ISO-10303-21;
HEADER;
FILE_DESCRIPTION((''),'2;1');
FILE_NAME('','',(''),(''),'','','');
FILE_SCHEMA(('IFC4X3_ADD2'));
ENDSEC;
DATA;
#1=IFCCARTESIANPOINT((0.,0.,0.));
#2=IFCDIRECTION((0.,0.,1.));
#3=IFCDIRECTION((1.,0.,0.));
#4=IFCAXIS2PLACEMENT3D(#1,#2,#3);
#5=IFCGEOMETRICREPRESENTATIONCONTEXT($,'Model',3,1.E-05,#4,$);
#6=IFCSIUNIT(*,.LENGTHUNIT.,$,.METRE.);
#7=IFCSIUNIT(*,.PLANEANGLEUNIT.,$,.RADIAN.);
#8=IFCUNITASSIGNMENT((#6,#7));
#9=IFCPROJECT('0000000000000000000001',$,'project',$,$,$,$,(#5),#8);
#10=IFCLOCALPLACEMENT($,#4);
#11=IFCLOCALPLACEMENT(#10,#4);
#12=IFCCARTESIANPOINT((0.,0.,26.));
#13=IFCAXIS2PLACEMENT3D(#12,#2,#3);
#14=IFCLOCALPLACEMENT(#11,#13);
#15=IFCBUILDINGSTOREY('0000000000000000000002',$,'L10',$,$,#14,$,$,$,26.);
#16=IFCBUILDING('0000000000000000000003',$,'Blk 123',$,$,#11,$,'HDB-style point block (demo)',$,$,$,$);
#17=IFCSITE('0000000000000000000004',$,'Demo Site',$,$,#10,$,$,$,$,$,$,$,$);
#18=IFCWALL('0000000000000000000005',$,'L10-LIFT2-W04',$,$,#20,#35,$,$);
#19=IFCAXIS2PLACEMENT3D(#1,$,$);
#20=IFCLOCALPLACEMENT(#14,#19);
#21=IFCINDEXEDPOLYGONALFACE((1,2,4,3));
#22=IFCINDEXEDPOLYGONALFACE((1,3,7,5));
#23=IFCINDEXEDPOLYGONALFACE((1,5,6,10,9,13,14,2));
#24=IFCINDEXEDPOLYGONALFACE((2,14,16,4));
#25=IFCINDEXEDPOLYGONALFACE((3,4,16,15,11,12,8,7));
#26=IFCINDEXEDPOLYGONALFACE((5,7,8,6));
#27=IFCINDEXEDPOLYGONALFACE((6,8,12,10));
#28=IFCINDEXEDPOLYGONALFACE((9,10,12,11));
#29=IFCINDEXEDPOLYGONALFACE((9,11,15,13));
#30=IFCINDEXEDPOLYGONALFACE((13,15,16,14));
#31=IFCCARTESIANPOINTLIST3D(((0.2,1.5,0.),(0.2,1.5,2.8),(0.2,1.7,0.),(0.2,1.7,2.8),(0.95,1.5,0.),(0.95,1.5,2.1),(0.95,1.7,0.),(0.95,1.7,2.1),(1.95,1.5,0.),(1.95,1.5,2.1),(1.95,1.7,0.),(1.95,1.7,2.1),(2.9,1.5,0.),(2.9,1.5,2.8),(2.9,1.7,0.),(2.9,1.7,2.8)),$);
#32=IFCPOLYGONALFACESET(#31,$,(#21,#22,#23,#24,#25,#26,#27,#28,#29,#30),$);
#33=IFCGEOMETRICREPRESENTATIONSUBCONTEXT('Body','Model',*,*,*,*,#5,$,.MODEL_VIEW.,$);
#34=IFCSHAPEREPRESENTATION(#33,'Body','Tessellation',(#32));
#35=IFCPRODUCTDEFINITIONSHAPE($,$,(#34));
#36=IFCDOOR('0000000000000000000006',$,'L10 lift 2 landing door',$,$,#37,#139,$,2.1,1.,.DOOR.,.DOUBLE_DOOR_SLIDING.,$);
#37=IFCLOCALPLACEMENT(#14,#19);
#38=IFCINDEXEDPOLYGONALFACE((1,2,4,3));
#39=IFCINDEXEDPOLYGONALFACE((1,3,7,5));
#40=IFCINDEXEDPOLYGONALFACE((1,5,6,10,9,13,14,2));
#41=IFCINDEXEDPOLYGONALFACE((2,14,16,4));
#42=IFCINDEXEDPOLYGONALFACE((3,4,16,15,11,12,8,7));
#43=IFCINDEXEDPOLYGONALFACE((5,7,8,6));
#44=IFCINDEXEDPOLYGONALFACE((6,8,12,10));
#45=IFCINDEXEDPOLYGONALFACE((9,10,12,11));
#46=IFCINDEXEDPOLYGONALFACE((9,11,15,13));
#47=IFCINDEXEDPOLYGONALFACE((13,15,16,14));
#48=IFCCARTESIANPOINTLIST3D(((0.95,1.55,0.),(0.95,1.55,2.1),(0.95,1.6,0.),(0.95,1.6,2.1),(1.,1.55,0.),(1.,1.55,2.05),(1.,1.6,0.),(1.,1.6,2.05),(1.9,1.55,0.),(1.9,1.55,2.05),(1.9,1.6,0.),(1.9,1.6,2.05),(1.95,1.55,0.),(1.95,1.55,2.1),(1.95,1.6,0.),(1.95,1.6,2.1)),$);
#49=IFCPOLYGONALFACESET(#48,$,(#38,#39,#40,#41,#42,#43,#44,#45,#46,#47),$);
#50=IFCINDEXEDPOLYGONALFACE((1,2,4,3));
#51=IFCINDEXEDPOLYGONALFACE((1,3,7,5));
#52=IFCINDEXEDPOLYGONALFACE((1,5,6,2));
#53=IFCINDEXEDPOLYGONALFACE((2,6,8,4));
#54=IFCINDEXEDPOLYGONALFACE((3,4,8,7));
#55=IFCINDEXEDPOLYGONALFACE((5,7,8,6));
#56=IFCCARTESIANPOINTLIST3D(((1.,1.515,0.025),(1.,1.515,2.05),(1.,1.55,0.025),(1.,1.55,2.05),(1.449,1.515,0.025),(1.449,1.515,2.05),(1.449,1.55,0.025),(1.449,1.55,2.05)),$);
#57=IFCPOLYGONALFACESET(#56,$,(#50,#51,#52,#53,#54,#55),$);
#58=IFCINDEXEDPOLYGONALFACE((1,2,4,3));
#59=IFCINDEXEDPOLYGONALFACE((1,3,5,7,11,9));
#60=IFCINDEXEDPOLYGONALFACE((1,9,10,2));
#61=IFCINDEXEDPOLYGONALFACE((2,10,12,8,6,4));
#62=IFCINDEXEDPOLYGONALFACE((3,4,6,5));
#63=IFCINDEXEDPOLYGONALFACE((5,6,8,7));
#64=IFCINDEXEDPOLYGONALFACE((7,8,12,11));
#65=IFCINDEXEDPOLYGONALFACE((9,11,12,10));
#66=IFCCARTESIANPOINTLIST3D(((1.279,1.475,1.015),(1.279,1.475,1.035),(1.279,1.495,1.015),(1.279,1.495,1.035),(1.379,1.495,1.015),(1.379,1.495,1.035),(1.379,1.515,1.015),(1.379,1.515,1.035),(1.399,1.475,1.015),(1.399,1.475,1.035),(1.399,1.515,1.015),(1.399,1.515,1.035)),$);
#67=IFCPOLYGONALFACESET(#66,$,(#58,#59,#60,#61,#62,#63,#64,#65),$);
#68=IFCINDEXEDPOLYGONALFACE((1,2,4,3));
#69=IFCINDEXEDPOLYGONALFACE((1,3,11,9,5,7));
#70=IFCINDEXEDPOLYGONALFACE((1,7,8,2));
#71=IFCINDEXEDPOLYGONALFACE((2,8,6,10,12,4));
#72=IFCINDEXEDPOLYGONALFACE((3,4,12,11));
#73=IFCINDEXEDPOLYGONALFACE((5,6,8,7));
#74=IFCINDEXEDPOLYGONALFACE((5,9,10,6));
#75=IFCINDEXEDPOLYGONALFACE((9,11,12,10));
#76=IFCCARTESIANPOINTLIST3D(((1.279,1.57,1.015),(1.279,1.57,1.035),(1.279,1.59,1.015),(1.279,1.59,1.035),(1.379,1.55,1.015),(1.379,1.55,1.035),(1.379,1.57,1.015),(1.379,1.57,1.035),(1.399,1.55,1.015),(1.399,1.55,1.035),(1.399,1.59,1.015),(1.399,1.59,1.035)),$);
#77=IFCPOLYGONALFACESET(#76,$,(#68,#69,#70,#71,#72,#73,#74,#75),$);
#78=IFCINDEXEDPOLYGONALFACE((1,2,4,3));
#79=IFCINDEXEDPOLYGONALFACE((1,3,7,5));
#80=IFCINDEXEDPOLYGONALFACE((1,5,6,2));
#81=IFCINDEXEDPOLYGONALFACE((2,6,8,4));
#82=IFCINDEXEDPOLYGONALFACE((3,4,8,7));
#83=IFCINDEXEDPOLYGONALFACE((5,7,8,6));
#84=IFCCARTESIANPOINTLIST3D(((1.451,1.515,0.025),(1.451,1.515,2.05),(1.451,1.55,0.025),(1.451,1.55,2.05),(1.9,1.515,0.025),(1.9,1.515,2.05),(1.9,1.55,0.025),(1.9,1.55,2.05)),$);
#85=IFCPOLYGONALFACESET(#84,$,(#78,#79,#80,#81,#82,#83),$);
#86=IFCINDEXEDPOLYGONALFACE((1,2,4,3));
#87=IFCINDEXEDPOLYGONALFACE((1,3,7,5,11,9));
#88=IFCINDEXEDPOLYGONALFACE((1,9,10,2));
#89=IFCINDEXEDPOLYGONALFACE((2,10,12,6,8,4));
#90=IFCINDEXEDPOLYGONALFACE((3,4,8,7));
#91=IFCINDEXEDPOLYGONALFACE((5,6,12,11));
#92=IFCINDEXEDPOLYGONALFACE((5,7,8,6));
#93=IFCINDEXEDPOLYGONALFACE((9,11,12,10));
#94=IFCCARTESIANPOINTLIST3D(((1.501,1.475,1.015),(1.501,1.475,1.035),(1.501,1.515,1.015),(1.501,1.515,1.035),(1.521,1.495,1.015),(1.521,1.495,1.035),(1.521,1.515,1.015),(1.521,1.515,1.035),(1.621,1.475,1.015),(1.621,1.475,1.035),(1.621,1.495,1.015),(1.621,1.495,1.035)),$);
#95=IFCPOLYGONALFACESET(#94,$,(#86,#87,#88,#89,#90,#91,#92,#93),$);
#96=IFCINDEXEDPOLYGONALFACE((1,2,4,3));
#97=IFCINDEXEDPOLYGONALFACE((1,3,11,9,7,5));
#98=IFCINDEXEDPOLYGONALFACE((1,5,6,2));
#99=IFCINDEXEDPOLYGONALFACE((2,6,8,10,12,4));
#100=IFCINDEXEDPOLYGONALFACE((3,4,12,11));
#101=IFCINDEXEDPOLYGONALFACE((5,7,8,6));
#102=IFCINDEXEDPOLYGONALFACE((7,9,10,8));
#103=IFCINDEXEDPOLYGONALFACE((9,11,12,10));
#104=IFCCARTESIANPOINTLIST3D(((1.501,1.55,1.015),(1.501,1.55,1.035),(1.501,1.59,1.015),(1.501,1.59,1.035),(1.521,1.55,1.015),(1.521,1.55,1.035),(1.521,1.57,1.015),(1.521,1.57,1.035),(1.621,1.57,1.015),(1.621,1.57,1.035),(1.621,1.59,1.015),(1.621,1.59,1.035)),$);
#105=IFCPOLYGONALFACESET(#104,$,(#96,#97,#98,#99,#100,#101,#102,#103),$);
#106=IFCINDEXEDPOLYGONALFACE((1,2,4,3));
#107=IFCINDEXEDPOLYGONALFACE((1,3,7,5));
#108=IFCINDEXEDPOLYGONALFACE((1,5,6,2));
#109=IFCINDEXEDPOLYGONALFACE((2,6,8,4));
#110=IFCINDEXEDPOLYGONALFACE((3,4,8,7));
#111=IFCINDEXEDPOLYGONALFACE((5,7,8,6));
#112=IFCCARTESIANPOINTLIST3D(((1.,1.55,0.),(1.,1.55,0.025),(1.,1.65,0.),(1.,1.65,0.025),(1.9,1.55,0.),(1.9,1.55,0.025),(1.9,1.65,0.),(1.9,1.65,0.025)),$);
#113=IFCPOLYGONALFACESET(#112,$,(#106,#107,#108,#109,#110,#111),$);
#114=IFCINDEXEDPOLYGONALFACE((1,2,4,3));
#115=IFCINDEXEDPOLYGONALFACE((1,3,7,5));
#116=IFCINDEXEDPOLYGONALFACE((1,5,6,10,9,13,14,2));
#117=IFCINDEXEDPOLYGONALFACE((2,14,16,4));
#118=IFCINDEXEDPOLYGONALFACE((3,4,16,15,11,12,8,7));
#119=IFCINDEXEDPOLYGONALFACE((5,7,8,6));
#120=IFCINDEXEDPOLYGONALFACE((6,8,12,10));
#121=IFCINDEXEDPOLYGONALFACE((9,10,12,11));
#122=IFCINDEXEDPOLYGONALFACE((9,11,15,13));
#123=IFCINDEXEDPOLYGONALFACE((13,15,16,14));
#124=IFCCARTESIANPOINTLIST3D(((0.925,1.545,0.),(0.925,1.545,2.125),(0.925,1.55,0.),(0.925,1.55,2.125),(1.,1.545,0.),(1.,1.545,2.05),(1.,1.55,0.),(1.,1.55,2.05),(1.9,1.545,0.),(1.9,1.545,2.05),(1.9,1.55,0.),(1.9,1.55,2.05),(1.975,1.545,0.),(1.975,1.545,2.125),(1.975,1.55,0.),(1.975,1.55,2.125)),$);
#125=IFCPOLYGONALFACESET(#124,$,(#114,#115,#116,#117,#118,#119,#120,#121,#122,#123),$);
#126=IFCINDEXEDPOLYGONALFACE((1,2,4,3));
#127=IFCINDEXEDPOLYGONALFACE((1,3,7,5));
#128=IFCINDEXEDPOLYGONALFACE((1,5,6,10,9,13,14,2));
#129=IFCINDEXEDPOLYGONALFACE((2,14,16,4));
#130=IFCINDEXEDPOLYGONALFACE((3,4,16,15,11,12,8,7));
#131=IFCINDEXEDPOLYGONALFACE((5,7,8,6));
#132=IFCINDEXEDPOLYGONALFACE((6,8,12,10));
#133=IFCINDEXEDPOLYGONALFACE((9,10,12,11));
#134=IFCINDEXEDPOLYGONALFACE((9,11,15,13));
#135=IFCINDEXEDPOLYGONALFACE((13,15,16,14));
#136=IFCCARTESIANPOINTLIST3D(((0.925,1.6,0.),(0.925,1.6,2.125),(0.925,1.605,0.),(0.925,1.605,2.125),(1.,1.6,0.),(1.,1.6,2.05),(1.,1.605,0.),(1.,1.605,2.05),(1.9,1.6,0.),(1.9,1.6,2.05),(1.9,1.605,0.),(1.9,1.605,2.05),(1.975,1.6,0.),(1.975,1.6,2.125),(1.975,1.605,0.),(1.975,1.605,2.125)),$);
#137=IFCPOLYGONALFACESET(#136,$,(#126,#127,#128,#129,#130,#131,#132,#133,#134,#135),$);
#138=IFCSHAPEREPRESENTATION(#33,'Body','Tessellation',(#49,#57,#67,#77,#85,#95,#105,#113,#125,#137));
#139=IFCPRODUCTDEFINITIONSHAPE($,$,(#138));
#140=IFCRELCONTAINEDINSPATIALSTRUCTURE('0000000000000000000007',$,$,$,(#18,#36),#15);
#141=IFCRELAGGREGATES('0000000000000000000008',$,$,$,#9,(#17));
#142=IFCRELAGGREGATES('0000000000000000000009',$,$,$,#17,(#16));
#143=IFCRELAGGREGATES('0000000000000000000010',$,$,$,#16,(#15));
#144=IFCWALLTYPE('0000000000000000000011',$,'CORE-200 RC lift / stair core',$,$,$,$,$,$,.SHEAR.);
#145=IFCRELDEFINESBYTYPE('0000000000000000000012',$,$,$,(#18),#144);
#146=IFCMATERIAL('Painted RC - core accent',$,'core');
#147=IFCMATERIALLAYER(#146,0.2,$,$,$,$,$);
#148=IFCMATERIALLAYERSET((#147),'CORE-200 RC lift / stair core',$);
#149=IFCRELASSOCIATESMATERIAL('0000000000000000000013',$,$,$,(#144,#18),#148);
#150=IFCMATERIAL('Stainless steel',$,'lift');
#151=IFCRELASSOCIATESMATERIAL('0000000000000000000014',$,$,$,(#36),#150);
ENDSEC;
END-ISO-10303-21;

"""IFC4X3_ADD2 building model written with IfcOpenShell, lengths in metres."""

from ifc_helpers import new_model, si_unit, frame, origin_with_axes, place, context, subcontext, project, spatial, line, indexed_curve, outline, extrude, material, layer, layer_set, layer_usage, type_object, element, fill, save


model = new_model("IFC4X3_ADD2")

# Units and contexts
model_context = context("Model", 3, precision=1e-05, world=origin_with_axes())
body_context = subcontext(model_context, "Body", "Model", "MODEL_VIEW")
ifc_project = project(units=[si_unit("LENGTHUNIT", "METRE"), si_unit("PLANEANGLEUNIT", "RADIAN")], contexts=[model_context])

# Site, building, storey
site_placement = place(None, origin_with_axes())
site = spatial("IfcSite", under=ifc_project, at=site_placement, Name="Demo Site")
building_placement = place(site_placement, origin_with_axes())
building = spatial("IfcBuilding", under=site, at=building_placement, Name="Blk 123", LongName="HDB-style point block (demo)")
storey_placement = place(building_placement, frame((0.0, 0.0, 26.0), z_axis=(0.0, 0.0, 1.0), x_axis=(1.0, 0.0, 0.0)))
storey = spatial("IfcBuildingStorey", under=building, at=storey_placement, Name="L10", Elevation=26.0)

# Shared definitions
ifc_material_1 = material(Name="Painted RC - core accent", Category="core")
ifc_layer_1 = layer(ifc_material_1, 0.2)
ifc_layer_set_1 = layer_set([ifc_layer_1], Name="CORE-200 RC lift / stair core")
ifc_layer_usage_1 = layer_usage(ifc_layer_set_1, "AXIS2", "POSITIVE", 0.0)
wall_type_1 = type_object("IfcWallType", Name="CORE-200 RC lift / stair core", PredefinedType="SHEAR", material=ifc_layer_set_1)

# Wall, opening, door
wall_1_placement = place(storey_placement, frame((0.2, 1.5, 0.0), z_axis=(0.0, 0.0, 1.0), x_axis=(1.0, 0.0, 0.0)))
wall_1 = element("IfcWall", 1, at=wall_1_placement, inside=storey, type_object=wall_type_1, material=ifc_layer_usage_1, Name="L10-LIFT2-W04", context=body_context, shape_type="SweptSolid", body=[
    extrude(outline(indexed_curve([(0.0, 0.0), (0.0, 0.2), (2.7, 0.2), (2.7, 0.0), (0.0, 0.0)], self_intersect=False)), origin_with_axes(), (0.0, 0.0, 1.0), 2.8),
])
opening_1_placement = place(wall_1_placement, frame((0.75, -0.1, 0.0), z_axis=(0.0, 0.0, 1.0), x_axis=(1.0, 0.0, 0.0)))
opening_1 = element("IfcOpeningElement", 2, at=opening_1_placement, cuts=wall_1, context=body_context, shape_type="SweptSolid", body=[
    extrude(outline(indexed_curve([(0.0, 0.0), (0.0, 0.4), (1.0, 0.4), (1.0, 0.0), (0.0, 0.0)], self_intersect=False)), origin_with_axes(), (0.0, 0.0, 1.0), 2.1),
])
ifc_material_2 = material(Name="Stainless steel", Category="lift")
door_1_placement = place(opening_1_placement, frame((0.0, 0.15, 0.0), z_axis=(0.0, 0.0, 1.0), x_axis=(1.0, 0.0, 0.0)))
door_1 = element("IfcDoor", 3, at=door_1_placement, inside=storey, material=ifc_material_2, Name="L10 lift 2 landing door", OperationType="DOUBLE_DOOR_SLIDING", OverallHeight=2.1, OverallWidth=1.0, PredefinedType="DOOR", context=body_context, shape_type="SweptSolid", body=[
    extrude(outline(indexed_curve([(0.0, 0.0), (0.0, 2.1), (1.0, 2.1), (1.0, 0.0), (0.95, 0.0), (0.95, 2.05), (0.05, 2.05), (0.05, 0.0)], segments=[line(1, 2, 3, 4, 5, 6, 7, 8, 1)])), frame((0.0, 0.0, 0.0), z_axis=(0.0, -1.0, 0.0), x_axis=(1.0, 0.0, 0.0)), (0.0, 0.0, -1.0), 0.05),
    extrude(outline(indexed_curve([(0.0, 0.0), (0.449, 0.0), (0.449, 0.035), (0.0, 0.035)], segments=[line(1, 2, 3, 4, 1)])), frame((0.05, -0.035, 0.025), z_axis=(0.0, 0.0, 1.0), x_axis=(1.0, 0.0, 0.0)), (0.0, 0.0, 1.0), 2.025),
    extrude(outline(indexed_curve([(0.0, 0.0), (0.0, -0.04), (-0.12, -0.04), (-0.12, -0.02), (-0.02, -0.02), (-0.02, 0.0)], segments=[line(1, 2, 3, 4, 5, 6, 1)])), frame((0.449, -0.035, 1.015), z_axis=(0.0, 0.0, 1.0), x_axis=(1.0, 0.0, 0.0)), (0.0, 0.0, 1.0), 0.02),
    extrude(outline(indexed_curve([(0.0, 0.0), (0.0, 0.04), (-0.12, 0.04), (-0.12, 0.02), (-0.02, 0.02), (-0.02, 0.0)], segments=[line(1, 2, 3, 4, 5, 6, 1)])), frame((0.449, 0.0, 1.015), z_axis=(0.0, 0.0, 1.0), x_axis=(1.0, 0.0, 0.0)), (0.0, 0.0, 1.0), 0.02),
    extrude(outline(indexed_curve([(0.0, 0.0), (-0.449, 0.0), (-0.449, 0.035), (0.0, 0.035)], segments=[line(1, 2, 3, 4, 1)])), frame((0.95, -0.035, 0.025), z_axis=(0.0, 0.0, 1.0), x_axis=(1.0, 0.0, 0.0)), (0.0, 0.0, 1.0), 2.025),
    extrude(outline(indexed_curve([(0.0, 0.0), (0.0, -0.04), (0.12, -0.04), (0.12, -0.02), (0.02, -0.02), (0.02, 0.0)], segments=[line(1, 2, 3, 4, 5, 6, 1)])), frame((0.551, -0.035, 1.015), z_axis=(0.0, 0.0, 1.0), x_axis=(1.0, 0.0, 0.0)), (0.0, 0.0, 1.0), 0.02),
    extrude(outline(indexed_curve([(0.0, 0.0), (0.0, 0.04), (0.12, 0.04), (0.12, 0.02), (0.02, 0.02), (0.02, 0.0)], segments=[line(1, 2, 3, 4, 5, 6, 1)])), frame((0.551, 0.0, 1.015), z_axis=(0.0, 0.0, 1.0), x_axis=(1.0, 0.0, 0.0)), (0.0, 0.0, 1.0), 0.02),
    extrude(outline(indexed_curve([(0.0, 0.0), (0.9, 0.0), (0.9, 0.1), (0.0, 0.1)], segments=[line(1, 2, 3, 4, 1)])), frame((0.05, 0.0, 0.0), z_axis=(0.0, 0.0, 1.0), x_axis=(1.0, 0.0, 0.0)), (0.0, 0.0, 1.0), 0.025),
    extrude(outline(indexed_curve([(0.0, 0.0), (0.0, 2.125), (1.05, 2.125), (1.05, 0.0), (0.975, 0.0), (0.975, 2.05), (0.075, 2.05), (0.075, 0.0)], segments=[line(1, 2, 3, 4, 5, 6, 7, 8, 1)])), frame((-0.025, -0.005, 0.0), z_axis=(0.0, -1.0, 0.0), x_axis=(1.0, 0.0, 0.0)), (0.0, 0.0, -1.0), 0.005),
    extrude(outline(indexed_curve([(0.0, 0.0), (0.0, 2.125), (1.05, 2.125), (1.05, 0.0), (0.975, 0.0), (0.975, 2.05), (0.075, 2.05), (0.075, 0.0)], segments=[line(1, 2, 3, 4, 5, 6, 7, 8, 1)])), frame((-0.025, 0.05, 0.0), z_axis=(0.0, -1.0, 0.0), x_axis=(1.0, 0.0, 0.0)), (0.0, 0.0, -1.0), 0.005),
])
fill(opening_1, door_1)

save(model, "model.ifc")
